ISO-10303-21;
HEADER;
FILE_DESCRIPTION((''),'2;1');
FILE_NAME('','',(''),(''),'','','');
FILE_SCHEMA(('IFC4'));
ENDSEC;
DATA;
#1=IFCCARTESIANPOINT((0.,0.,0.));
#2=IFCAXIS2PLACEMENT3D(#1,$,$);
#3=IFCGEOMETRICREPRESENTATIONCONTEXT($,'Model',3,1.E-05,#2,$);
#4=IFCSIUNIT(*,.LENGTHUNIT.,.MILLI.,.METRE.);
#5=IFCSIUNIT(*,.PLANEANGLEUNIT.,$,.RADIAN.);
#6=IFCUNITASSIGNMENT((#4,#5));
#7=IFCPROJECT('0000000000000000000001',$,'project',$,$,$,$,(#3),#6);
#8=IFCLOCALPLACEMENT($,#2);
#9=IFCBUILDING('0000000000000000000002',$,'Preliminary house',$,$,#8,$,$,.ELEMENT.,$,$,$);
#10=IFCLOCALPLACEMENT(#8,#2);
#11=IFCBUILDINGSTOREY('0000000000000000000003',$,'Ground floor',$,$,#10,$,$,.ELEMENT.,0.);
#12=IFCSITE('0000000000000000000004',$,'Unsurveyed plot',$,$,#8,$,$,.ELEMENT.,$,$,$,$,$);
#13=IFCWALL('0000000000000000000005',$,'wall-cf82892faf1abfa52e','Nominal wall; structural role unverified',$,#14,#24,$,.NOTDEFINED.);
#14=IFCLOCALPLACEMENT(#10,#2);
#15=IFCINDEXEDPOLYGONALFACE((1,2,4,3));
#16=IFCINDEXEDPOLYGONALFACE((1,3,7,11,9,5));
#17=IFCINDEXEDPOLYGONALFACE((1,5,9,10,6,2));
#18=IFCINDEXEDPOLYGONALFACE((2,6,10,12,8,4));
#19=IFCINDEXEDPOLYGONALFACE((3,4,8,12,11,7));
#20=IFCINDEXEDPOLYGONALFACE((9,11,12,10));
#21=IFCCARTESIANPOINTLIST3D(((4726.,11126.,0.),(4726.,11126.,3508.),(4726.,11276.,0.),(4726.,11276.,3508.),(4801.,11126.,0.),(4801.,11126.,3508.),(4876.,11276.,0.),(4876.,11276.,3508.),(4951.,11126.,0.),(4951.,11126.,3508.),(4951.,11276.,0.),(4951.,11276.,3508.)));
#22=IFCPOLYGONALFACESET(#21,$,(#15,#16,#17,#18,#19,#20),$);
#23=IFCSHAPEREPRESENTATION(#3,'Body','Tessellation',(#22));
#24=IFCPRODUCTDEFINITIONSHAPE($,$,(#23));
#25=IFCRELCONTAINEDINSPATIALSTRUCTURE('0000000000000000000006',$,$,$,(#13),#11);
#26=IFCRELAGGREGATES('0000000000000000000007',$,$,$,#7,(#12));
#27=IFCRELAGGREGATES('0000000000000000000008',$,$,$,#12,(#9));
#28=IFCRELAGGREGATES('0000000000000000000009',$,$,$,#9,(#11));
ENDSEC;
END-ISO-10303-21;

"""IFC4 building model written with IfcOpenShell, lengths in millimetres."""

from ifc_helpers import new_model, si_unit, origin, place, context, project, spatial, polyline, outline, extrude, element, save


model = new_model("IFC4")

# Units and contexts
model_context = context("Model", 3, precision=1e-05, world=origin())
ifc_project = project(units=[si_unit("LENGTHUNIT", "METRE", prefix="MILLI"), si_unit("PLANEANGLEUNIT", "RADIAN")], contexts=[model_context])

# Site, building, storey
placement_1 = place(None, origin())
site = spatial("IfcSite", under=ifc_project, at=placement_1, Name="Unsurveyed plot", CompositionType="ELEMENT")
building = spatial("IfcBuilding", under=site, at=placement_1, Name="Preliminary house", CompositionType="ELEMENT")
placement_2 = place(placement_1, origin())
storey = spatial("IfcBuildingStorey", under=building, at=placement_2, Name="Ground floor", CompositionType="ELEMENT", Elevation=0.0)

# Wall
element("IfcWall", 1, at=placement_2, inside=storey, Name="wall-cf82892faf1abfa52e", Description="Nominal wall; structural role unverified", PredefinedType="NOTDEFINED", context=model_context, shape_type="SweptSolid", body=[
    extrude(outline(polyline([(4876.0, 11276.0), (4951.0, 11276.0), (4951.0, 11126.0), (4801.0, 11126.0), (4726.0, 11126.0), (4726.0, 11276.0), (4876.0, 11276.0)])), origin(), (0.0, 0.0, 1.0), 3508.0),
])

save(model, "model.ifc")
